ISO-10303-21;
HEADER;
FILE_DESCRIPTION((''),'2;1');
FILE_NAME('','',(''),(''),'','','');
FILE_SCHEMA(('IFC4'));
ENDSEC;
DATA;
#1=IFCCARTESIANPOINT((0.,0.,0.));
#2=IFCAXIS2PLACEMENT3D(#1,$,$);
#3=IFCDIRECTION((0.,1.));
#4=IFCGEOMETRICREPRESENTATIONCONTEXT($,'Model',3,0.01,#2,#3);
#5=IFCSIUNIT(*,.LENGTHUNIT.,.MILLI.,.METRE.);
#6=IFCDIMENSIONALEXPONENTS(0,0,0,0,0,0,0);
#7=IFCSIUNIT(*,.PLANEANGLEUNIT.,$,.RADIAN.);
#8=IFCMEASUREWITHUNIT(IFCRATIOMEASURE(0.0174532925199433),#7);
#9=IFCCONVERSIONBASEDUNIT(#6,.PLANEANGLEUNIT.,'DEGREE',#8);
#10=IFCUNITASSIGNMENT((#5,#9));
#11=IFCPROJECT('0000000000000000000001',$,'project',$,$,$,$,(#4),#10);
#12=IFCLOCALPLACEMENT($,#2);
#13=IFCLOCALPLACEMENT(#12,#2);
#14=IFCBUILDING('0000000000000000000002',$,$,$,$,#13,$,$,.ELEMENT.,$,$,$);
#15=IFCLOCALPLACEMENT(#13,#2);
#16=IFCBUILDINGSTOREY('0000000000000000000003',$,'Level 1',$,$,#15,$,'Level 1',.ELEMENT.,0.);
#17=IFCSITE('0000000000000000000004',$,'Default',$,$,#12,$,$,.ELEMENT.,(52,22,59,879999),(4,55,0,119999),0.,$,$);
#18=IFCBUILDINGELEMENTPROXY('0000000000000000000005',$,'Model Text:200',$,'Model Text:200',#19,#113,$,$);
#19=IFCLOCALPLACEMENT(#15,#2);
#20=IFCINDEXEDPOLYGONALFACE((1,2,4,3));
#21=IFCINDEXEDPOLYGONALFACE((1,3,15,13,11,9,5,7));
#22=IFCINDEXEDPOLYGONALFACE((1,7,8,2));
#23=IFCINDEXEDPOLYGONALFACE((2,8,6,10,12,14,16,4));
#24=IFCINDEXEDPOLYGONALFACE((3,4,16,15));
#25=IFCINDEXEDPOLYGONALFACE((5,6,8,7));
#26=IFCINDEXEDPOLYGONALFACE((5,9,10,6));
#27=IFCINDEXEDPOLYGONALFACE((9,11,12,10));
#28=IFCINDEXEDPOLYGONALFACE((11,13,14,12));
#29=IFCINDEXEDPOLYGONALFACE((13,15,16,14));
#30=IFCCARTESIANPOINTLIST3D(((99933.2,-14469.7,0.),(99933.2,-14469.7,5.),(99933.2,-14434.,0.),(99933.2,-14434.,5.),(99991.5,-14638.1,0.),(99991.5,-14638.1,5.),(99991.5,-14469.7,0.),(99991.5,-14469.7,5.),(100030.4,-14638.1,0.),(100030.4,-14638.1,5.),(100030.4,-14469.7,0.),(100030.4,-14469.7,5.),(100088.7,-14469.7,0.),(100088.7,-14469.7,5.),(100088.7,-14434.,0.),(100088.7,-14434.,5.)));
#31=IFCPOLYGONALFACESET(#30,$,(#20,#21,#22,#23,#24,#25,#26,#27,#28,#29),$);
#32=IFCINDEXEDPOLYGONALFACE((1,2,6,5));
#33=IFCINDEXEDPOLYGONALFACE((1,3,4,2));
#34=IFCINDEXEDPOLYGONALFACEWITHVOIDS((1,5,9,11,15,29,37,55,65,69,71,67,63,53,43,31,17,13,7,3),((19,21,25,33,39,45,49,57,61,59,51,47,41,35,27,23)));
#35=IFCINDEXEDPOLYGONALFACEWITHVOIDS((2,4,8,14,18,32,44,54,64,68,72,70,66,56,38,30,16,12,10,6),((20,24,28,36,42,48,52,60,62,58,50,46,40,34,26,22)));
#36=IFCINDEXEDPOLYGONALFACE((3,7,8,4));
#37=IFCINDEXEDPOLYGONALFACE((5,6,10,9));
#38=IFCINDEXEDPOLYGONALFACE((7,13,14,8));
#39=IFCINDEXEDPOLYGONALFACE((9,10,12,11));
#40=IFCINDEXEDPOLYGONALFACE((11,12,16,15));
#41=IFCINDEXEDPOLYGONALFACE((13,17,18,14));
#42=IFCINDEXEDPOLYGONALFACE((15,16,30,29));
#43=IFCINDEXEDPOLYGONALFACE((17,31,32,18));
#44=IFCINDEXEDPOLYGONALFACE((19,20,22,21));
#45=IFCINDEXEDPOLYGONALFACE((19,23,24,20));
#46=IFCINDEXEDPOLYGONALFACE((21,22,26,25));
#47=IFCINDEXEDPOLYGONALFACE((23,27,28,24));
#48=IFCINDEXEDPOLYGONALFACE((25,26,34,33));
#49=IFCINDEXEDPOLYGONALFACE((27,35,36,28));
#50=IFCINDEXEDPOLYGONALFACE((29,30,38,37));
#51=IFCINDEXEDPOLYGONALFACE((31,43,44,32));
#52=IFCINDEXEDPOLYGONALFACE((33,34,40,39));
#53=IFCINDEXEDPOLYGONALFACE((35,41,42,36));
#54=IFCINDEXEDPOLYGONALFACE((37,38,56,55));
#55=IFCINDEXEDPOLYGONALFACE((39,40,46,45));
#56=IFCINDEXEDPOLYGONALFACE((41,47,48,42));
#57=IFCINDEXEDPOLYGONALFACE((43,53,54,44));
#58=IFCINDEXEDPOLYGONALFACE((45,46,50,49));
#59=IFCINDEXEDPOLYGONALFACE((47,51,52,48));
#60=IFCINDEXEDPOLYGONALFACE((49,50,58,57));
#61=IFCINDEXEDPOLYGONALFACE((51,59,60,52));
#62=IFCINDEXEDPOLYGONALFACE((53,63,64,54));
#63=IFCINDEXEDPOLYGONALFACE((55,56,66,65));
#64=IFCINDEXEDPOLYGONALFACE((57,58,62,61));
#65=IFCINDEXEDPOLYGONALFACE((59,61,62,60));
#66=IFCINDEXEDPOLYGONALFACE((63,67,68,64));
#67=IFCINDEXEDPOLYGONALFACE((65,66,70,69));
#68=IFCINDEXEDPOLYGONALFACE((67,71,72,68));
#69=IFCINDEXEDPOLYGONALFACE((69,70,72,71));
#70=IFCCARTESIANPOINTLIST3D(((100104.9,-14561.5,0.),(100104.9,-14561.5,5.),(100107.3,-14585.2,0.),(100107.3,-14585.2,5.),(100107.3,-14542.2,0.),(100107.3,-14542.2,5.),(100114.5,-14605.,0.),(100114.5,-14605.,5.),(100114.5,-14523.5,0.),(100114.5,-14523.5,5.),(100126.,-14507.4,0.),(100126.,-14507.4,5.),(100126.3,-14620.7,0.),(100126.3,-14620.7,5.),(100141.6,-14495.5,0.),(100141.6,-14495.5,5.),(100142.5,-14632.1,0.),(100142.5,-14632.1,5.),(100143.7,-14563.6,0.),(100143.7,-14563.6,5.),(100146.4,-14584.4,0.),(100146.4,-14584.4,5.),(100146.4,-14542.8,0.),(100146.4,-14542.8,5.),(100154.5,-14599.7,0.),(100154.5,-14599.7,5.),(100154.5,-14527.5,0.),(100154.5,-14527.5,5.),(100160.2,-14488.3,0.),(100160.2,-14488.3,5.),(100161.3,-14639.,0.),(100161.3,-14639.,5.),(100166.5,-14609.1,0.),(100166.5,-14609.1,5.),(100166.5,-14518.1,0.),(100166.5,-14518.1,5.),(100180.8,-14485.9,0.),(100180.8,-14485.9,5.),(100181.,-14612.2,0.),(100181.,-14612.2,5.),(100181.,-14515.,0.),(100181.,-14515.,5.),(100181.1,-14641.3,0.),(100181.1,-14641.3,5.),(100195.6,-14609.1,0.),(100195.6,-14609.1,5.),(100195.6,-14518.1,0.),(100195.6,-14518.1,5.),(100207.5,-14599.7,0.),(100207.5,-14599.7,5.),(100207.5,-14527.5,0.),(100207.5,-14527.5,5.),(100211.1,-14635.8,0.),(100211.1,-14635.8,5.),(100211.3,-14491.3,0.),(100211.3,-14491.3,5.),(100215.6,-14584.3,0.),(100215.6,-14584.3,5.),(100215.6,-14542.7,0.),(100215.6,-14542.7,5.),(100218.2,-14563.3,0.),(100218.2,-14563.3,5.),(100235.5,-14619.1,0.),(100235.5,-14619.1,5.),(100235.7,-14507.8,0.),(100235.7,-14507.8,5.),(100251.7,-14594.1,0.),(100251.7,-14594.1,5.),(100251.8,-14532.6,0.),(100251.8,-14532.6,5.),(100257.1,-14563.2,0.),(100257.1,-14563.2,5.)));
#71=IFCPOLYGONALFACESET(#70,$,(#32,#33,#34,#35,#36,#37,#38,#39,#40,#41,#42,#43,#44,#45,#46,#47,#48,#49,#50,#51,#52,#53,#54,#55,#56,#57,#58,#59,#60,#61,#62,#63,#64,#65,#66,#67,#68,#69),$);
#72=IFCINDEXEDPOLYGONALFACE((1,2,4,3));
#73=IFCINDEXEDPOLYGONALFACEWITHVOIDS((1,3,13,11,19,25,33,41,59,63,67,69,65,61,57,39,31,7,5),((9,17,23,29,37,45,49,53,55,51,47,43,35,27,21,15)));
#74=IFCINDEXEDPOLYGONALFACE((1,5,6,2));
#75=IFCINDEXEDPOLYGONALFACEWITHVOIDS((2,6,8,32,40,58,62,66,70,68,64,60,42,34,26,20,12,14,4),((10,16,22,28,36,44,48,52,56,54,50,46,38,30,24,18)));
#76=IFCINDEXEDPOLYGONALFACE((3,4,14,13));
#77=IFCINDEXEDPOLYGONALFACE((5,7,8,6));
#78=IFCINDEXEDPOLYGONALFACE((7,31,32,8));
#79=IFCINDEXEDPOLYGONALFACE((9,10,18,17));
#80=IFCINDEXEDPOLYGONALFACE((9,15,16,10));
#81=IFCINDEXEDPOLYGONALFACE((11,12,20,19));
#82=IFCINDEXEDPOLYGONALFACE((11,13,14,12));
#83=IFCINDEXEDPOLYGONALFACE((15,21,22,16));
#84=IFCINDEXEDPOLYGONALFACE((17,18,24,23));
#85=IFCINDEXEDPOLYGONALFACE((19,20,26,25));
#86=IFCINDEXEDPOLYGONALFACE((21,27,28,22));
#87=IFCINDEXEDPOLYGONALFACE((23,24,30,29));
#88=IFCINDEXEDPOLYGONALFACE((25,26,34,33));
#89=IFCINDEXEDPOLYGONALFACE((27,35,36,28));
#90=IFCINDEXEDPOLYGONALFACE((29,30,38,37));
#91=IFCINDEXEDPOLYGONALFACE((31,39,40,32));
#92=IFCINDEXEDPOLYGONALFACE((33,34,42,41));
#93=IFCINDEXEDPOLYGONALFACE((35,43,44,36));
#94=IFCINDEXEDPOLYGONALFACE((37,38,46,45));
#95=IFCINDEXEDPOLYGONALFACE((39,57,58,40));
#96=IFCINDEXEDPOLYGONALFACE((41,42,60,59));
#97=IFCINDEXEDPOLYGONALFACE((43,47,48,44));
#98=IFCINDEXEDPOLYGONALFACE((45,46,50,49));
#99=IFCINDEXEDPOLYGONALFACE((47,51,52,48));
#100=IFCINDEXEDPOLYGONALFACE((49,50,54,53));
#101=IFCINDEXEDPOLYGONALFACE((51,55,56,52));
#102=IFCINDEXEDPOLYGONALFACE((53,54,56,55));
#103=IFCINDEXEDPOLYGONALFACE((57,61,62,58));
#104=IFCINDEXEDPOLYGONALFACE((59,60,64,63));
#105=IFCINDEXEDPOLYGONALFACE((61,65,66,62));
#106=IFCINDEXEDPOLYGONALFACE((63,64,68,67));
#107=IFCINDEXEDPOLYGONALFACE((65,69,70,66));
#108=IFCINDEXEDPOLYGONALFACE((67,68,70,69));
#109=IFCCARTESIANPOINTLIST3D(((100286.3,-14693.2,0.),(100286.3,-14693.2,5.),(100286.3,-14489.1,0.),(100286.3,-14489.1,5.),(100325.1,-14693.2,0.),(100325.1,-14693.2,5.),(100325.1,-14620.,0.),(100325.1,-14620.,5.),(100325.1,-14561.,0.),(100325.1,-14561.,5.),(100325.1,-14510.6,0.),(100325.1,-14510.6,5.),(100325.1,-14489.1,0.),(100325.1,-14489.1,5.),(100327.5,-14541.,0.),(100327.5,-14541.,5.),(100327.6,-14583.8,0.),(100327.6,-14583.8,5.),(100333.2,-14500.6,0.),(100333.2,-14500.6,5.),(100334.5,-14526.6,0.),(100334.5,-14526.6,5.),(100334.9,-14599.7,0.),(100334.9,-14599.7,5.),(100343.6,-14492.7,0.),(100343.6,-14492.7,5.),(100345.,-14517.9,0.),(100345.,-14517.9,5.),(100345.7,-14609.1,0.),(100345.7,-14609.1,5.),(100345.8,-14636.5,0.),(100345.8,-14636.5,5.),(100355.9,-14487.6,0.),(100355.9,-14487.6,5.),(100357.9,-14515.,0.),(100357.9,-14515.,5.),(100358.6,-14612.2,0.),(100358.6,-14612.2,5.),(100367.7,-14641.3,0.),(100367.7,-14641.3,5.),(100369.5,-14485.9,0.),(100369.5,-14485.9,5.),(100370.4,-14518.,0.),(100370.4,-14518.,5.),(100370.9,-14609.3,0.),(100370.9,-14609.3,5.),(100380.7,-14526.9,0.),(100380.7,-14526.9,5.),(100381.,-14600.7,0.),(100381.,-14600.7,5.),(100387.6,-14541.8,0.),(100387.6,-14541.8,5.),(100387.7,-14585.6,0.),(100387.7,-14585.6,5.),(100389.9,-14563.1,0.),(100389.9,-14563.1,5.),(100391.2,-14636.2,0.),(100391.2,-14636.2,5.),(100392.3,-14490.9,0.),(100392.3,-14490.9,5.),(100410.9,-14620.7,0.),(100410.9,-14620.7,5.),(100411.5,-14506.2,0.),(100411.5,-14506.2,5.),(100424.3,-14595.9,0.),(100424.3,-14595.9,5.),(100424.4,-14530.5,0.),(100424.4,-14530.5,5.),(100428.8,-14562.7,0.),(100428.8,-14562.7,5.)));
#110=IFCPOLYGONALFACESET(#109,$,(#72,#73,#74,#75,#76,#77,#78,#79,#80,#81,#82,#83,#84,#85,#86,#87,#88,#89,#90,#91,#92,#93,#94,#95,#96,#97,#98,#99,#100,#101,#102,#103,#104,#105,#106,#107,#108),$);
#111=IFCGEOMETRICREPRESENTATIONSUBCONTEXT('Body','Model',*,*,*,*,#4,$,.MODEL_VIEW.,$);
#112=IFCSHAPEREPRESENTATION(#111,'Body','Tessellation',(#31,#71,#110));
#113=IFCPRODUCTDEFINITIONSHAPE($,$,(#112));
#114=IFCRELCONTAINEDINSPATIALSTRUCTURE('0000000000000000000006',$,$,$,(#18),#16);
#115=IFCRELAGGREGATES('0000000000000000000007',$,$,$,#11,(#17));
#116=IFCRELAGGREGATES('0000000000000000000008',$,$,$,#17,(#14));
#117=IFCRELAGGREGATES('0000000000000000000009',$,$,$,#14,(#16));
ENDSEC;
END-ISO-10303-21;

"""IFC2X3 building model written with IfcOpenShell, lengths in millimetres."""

from ifc_helpers import new_model, entity, si_unit, converted_unit, direction, frame, origin, place, context, subcontext, project, spatial, polyline, outline, extrude, element, save


model = new_model("IFC2X3")

# Units and contexts
model_context = context("Model", 3, precision=0.01, world=origin(), true_north=direction((0.0, 1.0)))
body_context = subcontext(model_context, "Body", "Model", "MODEL_VIEW")
ifc_project = project(units=[si_unit("LENGTHUNIT", "METRE", prefix="MILLI"), converted_unit("PLANEANGLEUNIT", "DEGREE", entity("IfcRatioMeasure", 0.0174532925199433), si_unit("PLANEANGLEUNIT", "RADIAN"), dimensions=[0, 0, 0, 0, 0, 0, 0])], contexts=[model_context])

# Site, building, storey
site_placement = place(None, origin())
site = spatial("IfcSite", under=ifc_project, at=site_placement, Name="Default", CompositionType="ELEMENT", RefLatitude=(52, 22, 59, 879999), RefLongitude=(4, 55, 0, 119999), RefElevation=0.0)
building_placement = place(site_placement, origin())
building = spatial("IfcBuilding", under=site, at=building_placement, CompositionType="ELEMENT")
storey_placement = place(building_placement, origin())
storey = spatial("IfcBuildingStorey", under=building, at=storey_placement, Name="Level 1", LongName="Level 1", CompositionType="ELEMENT", Elevation=0.0)

# Building element proxy
proxy_1_placement = place(building_placement, origin())
element("IfcBuildingElementProxy", 1, at=proxy_1_placement, inside=storey, Name="Model Text:200", ObjectType="Model Text:200", context=body_context, shape_type="SweptSolid", body=[
    extrude(outline(polyline([(-19.4, -135.2), (19.4, -135.2), (19.4, 33.2), (77.7, 33.2), (77.7, 68.8), (-77.7, 68.8), (-77.7, 33.2), (-19.4, 33.2), (-19.4, -135.2)])), frame((100010.9, -14502.9, 0.0)), (0.0, 0.0, 1.0), 5.0),
    extrude(outline(polyline([(-8.8, -65.7), (15.1, -65.7), (35.5, -60.5), (52.3, -50.4), (65.3, -35.4), (74.1, -17.3), (78.4, 2.1), (75.9, 32.5), (61.8, 58.5), (38.4, 77.1), (8.3, 85.6), (-22.7, 83.3), (-49.0, 69.9), (-67.8, 47.3), (-76.3, 17.5), (-76.0, -3.3), (-70.7, -22.5), (-60.5, -39.2), (-45.5, -52.3), (-27.7, -61.4), (-8.8, -65.7)]), holes=[polyline([(-2.7, -27.2), (-23.1, -22.5), (-37.5, -12.9), (-45.7, 0.0), (-47.3, 14.8), (-42.7, 28.9), (-32.2, 39.9), (-16.3, 46.3), (4.5, 46.9), (25.1, 42.1), (39.6, 32.6), (47.7, 19.7), (49.4, 5.0), (44.8, -9.2), (34.2, -20.2), (18.2, -26.7), (-2.7, -27.2)])]), frame((100171.1, -14563.6, 0.0), z_axis=(0.0, 0.0, 1.0), x_axis=(0.100608, -0.994926, 0.0)), (0.0, 0.0, 1.0), 5.0),
    extrude(outline(polyline([(-73.1, -75.4), (130.9, -75.4), (130.9, -36.6), (57.8, -36.6), (74.3, -15.9), (79.1, 6.0), (73.9, 29.5), (58.4, 49.2), (33.6, 62.6), (0.5, 67.1), (-31.8, 62.8), (-56.1, 49.8), (-71.3, 30.7), (-76.4, 7.8), (-74.7, -5.8), (-69.6, -18.1), (-61.7, -28.5), (-51.7, -36.6), (-73.1, -36.6), (-73.1, -75.4)]), holes=[polyline([(-1.2, -36.6), (-21.2, -34.2), (-35.6, -27.2), (-44.3, -16.7), (-47.2, -3.8), (-44.3, 8.7), (-35.4, 19.0), (-20.4, 25.9), (0.8, 28.2), (23.3, 26.0), (38.5, 19.3), (47.1, 9.2), (49.9, -3.1), (46.8, -16.0), (37.4, -26.8), (21.5, -34.1), (-1.2, -36.6)])]), frame((100361.7, -14562.3, 0.0), z_axis=(0.0, 0.0, 1.0), x_axis=(0.0, -1.0, 0.0)), (0.0, 0.0, 1.0), 5.0),
])

save(model, "model.ifc")
